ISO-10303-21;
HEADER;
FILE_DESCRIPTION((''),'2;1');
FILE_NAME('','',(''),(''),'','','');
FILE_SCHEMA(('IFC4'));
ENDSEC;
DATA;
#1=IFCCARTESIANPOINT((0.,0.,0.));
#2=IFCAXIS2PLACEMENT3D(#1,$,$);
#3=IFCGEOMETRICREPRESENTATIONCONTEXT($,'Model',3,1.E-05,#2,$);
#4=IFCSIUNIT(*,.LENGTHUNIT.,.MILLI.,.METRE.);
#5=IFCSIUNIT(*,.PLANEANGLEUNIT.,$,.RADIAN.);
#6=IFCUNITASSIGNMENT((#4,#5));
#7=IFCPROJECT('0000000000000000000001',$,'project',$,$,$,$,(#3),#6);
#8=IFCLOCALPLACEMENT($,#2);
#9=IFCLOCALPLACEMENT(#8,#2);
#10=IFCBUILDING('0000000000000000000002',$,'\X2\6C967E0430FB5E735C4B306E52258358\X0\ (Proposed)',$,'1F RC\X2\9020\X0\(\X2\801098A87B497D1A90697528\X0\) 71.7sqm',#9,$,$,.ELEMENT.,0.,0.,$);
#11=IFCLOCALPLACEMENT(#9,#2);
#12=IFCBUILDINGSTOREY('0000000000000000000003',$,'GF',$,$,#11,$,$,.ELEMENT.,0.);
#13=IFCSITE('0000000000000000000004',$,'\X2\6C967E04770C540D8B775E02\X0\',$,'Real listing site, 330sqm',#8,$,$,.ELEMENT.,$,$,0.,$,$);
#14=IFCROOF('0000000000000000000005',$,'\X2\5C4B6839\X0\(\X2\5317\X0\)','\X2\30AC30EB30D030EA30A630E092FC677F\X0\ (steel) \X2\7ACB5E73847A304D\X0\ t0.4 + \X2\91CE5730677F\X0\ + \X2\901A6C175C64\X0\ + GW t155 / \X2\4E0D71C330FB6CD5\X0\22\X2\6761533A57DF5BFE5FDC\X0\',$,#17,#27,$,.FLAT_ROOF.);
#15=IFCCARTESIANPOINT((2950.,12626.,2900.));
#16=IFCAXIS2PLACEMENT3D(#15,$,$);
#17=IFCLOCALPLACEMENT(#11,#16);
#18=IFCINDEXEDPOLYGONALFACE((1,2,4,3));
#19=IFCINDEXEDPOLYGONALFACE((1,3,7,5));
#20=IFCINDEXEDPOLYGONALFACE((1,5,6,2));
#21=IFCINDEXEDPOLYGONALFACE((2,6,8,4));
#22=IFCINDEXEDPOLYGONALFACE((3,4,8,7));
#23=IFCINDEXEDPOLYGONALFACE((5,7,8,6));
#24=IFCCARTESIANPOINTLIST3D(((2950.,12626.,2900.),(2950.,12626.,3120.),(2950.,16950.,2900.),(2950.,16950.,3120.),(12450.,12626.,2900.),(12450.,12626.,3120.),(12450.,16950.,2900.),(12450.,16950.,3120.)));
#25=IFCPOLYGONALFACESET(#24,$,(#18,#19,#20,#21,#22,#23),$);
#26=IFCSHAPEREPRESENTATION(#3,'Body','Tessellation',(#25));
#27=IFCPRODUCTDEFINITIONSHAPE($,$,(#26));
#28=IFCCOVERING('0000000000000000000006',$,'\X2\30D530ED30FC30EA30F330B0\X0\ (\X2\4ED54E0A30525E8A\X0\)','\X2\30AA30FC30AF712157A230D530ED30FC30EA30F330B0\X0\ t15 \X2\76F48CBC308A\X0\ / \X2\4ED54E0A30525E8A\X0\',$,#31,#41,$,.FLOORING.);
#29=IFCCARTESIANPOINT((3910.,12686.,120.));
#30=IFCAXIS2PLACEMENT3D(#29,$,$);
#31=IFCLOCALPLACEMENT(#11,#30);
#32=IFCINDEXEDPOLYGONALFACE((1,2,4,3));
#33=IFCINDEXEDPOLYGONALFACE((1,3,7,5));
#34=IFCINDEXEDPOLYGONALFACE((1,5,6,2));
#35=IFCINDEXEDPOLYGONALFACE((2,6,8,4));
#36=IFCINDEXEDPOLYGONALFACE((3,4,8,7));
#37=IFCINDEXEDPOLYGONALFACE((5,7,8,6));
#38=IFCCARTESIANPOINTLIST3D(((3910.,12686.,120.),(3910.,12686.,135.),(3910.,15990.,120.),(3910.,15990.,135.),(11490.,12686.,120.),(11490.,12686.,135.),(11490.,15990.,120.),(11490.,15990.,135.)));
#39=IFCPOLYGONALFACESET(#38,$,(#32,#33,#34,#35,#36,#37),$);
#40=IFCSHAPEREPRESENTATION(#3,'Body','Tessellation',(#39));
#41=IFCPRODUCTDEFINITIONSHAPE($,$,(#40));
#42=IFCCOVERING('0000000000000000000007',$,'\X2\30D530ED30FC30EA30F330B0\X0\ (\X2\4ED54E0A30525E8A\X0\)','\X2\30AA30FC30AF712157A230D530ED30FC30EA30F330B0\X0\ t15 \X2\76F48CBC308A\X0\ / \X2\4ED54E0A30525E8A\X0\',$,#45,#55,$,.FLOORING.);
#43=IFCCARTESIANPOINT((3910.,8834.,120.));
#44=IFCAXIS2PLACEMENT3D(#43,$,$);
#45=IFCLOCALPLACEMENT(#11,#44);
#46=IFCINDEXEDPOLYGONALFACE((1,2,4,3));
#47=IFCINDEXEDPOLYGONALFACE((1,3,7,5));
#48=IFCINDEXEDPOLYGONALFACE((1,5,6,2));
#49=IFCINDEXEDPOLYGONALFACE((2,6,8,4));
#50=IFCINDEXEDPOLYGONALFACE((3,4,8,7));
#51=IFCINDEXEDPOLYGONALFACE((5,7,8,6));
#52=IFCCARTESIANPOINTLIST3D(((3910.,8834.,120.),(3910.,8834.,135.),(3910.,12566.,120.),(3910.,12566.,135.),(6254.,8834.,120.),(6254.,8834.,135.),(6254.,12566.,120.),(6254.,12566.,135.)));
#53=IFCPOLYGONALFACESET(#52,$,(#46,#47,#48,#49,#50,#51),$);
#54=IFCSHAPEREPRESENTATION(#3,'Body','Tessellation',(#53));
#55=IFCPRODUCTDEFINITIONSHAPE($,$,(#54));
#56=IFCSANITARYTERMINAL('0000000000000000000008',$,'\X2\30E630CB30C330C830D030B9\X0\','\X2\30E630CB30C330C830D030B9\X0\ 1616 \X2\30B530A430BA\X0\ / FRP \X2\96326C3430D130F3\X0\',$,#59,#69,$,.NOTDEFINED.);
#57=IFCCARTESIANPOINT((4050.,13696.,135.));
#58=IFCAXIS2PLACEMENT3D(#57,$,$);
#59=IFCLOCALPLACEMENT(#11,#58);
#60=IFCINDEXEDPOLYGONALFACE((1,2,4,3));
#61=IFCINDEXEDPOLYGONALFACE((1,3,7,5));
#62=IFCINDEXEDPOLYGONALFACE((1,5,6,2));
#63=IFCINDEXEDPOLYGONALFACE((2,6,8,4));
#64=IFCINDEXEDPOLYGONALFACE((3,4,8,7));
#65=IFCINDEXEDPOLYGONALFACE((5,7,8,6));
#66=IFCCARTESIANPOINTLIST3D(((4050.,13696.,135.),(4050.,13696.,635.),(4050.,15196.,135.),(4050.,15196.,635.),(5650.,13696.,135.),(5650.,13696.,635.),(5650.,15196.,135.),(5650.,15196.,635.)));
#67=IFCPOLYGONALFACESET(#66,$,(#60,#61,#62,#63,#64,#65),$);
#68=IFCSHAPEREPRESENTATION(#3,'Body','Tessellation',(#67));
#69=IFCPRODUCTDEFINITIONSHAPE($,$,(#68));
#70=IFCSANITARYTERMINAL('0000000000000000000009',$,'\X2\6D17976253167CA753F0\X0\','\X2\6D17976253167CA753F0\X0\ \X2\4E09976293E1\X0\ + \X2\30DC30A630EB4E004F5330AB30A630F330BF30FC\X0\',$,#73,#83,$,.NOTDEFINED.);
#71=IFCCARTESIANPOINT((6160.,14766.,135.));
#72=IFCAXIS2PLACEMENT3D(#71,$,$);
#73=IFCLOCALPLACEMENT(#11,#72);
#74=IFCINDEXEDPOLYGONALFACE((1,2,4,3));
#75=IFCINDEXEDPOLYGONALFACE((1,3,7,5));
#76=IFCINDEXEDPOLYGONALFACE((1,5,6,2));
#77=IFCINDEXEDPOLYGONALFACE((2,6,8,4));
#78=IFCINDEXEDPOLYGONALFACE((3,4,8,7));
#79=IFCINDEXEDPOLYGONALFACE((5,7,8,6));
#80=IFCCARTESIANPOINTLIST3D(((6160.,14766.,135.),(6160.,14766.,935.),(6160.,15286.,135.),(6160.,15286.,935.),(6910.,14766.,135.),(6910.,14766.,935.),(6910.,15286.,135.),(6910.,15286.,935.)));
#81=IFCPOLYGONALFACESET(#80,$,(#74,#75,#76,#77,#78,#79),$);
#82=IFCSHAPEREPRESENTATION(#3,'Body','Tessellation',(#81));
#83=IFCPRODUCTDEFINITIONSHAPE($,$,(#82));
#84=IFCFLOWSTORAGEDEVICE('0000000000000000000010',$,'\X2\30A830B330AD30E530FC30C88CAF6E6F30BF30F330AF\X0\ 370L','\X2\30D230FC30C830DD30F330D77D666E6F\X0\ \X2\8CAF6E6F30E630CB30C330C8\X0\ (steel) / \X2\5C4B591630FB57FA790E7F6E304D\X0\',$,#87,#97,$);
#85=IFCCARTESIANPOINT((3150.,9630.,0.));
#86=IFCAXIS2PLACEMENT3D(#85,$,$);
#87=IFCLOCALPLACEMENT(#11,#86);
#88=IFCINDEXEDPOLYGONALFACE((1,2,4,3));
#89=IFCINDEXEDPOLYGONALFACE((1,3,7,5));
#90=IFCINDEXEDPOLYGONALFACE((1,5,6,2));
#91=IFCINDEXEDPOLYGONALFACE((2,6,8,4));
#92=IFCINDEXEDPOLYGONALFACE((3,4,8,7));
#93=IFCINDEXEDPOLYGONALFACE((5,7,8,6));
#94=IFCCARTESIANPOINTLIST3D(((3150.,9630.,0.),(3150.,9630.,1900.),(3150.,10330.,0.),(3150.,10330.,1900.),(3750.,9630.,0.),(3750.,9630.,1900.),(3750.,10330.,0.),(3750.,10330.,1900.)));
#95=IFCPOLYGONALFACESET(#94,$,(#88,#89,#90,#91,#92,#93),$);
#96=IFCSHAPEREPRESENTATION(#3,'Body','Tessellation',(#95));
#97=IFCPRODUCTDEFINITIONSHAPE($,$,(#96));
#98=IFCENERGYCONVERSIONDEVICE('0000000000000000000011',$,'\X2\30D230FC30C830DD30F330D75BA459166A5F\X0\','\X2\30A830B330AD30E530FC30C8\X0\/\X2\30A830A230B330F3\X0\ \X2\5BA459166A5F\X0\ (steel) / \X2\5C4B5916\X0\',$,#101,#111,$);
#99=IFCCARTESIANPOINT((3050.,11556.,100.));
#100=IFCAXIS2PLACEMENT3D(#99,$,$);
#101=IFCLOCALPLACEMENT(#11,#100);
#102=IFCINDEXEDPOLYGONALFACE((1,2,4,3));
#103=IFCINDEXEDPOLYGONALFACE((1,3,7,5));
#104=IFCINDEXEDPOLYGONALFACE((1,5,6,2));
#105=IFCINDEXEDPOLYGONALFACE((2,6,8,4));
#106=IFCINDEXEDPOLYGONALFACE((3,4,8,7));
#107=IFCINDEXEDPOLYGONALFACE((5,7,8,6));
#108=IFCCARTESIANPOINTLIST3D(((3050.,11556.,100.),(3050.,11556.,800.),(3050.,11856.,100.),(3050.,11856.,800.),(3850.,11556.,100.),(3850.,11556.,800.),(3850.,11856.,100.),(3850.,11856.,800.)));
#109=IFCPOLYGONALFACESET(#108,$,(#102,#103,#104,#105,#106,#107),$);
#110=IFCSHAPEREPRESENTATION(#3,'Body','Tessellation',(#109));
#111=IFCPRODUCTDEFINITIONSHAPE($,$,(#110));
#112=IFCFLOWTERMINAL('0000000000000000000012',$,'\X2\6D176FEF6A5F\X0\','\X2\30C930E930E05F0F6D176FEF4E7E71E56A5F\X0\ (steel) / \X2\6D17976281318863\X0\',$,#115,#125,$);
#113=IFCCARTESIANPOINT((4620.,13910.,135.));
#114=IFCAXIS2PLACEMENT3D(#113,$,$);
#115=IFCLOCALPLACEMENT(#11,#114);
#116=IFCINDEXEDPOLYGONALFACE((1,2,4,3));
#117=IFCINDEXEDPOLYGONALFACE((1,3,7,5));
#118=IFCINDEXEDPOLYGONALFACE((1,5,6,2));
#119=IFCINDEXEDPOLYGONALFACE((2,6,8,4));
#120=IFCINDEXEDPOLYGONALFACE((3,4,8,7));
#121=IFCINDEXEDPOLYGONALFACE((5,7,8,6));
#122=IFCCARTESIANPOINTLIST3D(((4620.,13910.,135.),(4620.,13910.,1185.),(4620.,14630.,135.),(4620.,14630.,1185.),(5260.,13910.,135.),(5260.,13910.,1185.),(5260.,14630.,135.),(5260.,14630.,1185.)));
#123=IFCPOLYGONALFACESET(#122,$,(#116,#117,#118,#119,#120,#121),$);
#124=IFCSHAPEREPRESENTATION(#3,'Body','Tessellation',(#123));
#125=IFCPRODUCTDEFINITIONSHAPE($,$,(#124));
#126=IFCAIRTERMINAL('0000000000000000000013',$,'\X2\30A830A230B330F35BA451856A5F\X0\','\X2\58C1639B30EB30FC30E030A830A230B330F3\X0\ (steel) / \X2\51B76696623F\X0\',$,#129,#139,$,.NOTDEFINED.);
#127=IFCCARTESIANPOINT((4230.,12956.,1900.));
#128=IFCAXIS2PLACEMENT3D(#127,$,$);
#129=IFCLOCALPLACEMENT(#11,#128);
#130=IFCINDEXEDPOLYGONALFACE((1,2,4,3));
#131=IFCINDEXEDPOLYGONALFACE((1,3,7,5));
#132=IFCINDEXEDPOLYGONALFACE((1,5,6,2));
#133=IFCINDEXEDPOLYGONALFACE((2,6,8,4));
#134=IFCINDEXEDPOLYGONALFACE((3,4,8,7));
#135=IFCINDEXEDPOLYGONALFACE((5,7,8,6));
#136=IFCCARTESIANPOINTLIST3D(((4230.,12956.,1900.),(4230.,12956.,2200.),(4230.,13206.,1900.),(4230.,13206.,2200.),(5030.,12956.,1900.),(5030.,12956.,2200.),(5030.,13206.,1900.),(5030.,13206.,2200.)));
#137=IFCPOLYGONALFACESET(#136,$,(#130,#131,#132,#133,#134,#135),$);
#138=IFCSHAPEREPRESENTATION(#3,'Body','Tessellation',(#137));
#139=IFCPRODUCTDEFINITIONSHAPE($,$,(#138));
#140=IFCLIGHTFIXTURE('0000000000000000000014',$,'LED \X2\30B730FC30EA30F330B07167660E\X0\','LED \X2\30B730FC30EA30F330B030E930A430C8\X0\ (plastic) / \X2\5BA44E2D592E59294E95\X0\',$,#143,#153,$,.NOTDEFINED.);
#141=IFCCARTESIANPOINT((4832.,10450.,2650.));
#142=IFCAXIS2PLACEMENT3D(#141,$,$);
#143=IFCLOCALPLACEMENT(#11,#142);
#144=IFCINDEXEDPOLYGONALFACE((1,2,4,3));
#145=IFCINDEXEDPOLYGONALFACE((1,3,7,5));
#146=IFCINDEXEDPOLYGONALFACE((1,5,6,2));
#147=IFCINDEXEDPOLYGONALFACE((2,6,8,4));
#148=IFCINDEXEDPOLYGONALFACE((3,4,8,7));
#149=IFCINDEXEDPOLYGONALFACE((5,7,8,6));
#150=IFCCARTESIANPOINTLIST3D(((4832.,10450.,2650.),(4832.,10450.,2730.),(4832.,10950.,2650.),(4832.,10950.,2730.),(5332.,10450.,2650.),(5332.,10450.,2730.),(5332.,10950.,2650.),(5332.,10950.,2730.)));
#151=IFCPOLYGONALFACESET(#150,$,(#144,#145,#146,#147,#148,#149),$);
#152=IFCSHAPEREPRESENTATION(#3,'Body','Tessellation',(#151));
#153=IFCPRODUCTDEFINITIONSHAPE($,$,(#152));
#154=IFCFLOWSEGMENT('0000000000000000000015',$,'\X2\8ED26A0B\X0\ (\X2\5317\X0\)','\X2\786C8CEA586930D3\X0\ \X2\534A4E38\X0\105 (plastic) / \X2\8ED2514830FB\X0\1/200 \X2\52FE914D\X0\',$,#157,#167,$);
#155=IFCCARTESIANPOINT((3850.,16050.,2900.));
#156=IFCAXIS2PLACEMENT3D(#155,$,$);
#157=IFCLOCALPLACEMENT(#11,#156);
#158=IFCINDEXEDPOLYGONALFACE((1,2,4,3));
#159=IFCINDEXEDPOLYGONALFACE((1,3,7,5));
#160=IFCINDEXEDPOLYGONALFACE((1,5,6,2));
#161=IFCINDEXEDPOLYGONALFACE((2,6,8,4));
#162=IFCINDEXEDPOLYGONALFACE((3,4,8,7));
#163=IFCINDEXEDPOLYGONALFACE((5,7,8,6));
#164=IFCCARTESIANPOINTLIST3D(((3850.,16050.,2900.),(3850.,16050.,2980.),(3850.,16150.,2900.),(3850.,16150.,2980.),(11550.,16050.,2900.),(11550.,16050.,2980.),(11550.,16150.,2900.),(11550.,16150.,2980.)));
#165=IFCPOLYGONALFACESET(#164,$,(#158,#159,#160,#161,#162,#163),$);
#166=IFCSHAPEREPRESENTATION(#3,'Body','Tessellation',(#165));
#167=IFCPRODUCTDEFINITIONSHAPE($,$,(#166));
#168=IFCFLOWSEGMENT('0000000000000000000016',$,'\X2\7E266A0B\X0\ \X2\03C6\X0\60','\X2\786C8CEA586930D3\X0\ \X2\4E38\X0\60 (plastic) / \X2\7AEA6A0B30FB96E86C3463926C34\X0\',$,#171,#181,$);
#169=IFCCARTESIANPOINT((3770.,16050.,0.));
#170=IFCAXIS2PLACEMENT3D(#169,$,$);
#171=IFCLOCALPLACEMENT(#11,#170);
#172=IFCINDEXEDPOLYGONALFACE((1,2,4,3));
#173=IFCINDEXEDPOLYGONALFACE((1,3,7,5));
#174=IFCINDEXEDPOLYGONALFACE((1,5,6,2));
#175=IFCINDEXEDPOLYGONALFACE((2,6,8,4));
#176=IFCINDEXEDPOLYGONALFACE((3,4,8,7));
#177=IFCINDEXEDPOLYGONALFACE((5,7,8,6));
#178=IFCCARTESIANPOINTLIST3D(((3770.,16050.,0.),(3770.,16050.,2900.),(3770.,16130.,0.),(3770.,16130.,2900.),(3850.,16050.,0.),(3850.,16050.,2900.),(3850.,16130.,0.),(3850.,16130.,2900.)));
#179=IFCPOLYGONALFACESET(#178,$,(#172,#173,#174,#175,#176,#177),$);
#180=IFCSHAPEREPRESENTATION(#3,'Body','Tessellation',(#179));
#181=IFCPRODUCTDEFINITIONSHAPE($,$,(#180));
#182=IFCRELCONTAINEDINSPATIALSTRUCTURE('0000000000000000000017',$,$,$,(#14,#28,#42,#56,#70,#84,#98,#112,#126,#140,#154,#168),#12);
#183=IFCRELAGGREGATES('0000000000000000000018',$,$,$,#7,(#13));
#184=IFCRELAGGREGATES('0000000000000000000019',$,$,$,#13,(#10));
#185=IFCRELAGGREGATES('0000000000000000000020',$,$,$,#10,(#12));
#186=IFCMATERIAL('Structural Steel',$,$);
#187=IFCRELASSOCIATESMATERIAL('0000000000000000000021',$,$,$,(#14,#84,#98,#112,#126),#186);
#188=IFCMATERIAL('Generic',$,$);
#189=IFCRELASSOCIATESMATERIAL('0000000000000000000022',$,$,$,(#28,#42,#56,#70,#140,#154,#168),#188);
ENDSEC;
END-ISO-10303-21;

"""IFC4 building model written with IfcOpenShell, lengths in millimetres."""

from ifc_helpers import new_model, si_unit, frame, frame_2d, origin, place, context, project, spatial, rectangle, extrude, material, element, save


model = new_model("IFC4")

# Units and contexts
model_context = context("Model", 3, precision=1e-05, world=origin())
ifc_project = project(units=[si_unit("LENGTHUNIT", "METRE", prefix="MILLI"), si_unit("PLANEANGLEUNIT", "RADIAN")], contexts=[model_context])

# Site, building, storey
site_placement = place(None, origin())
site = spatial("IfcSite", under=ifc_project, at=site_placement, Name="沖縄県名護市", ObjectType="Real listing site, 330sqm", CompositionType="ELEMENT", RefElevation=0.0)
building_placement = place(site_placement, origin())
building = spatial("IfcBuilding", under=site, at=building_placement, Name="沖縄・平屋の別荘 (Proposed)", ObjectType="1F RC造(耐風等級適用) 71.7sqm", CompositionType="ELEMENT", ElevationOfRefHeight=0.0, ElevationOfTerrain=0.0)
storey_placement = place(building_placement, origin())
storey = spatial("IfcBuildingStorey", under=building, at=storey_placement, Name="GF", CompositionType="ELEMENT", Elevation=0.0)

# Roof
ifc_material_1 = material(Name="Structural Steel")
roof_placement = place(storey_placement, frame((2950.0, 12626.0, 2900.0)))
element("IfcRoof", 1, at=roof_placement, inside=storey, material=ifc_material_1, Name="屋根(北)", Description="ガルバリウム鋼板 (steel) 立平葺き t0.4 + 野地板 + 通気層 + GW t155 / 不燃・法22条区域対応", PredefinedType="FLAT_ROOF", context=model_context, shape_type="SweptSolid", body=[
    extrude(rectangle(XDim=9500.0, YDim=4324.0, at=frame_2d((4750.0, 2162.0))), frame((2950.0, 12626.0, 2900.0)), (0.0, 0.0, 1.0), 220.0),
])

# Coverings
ifc_material_2 = material(Name="Generic")
covering_1_placement = place(storey_placement, frame((3910.0, 12686.0, 120.0)))
element("IfcCovering", 2, at=covering_1_placement, inside=storey, material=ifc_material_2, Name="フローリング (仕上げ床)", Description="オーク無垢フローリング t15 直貼り / 仕上げ床", PredefinedType="FLOORING", context=model_context, shape_type="SweptSolid", body=[
    extrude(rectangle(XDim=7580.0, YDim=3304.0, at=frame_2d((3790.0, 1652.0))), frame((3910.0, 12686.0, 120.0)), (0.0, 0.0, 1.0), 15.0),
])
covering_2_placement = place(storey_placement, frame((3910.0, 8834.0, 120.0)))
element("IfcCovering", 3, at=covering_2_placement, inside=storey, material=ifc_material_2, Name="フローリング (仕上げ床)", Description="オーク無垢フローリング t15 直貼り / 仕上げ床", PredefinedType="FLOORING", context=model_context, shape_type="SweptSolid", body=[
    extrude(rectangle(XDim=2344.0, YDim=3732.0, at=frame_2d((1172.0, 1866.0))), frame((3910.0, 8834.0, 120.0)), (0.0, 0.0, 1.0), 15.0),
])

# Sanitary terminals
sanitary_terminal_1_placement = place(storey_placement, frame((4050.0, 13696.0, 135.0)))
element("IfcSanitaryTerminal", 4, at=sanitary_terminal_1_placement, inside=storey, material=ifc_material_2, Name="ユニットバス", Description="ユニットバス 1616 サイズ / FRP 防水パン", PredefinedType="NOTDEFINED", context=model_context, shape_type="SweptSolid", body=[
    extrude(rectangle(XDim=1600.0, YDim=1500.0, at=frame_2d((800.0, 750.0))), frame((4050.0, 13696.0, 135.0)), (0.0, 0.0, 1.0), 500.0),
])
sanitary_terminal_2_placement = place(storey_placement, frame((6160.0, 14766.0, 135.0)))
element("IfcSanitaryTerminal", 5, at=sanitary_terminal_2_placement, inside=storey, material=ifc_material_2, Name="洗面化粧台", Description="洗面化粧台 三面鏡 + ボウル一体カウンター", PredefinedType="NOTDEFINED", context=model_context, shape_type="SweptSolid", body=[
    extrude(rectangle(XDim=750.0, YDim=520.0, at=frame_2d((375.0, 260.0))), frame((6160.0, 14766.0, 135.0)), (0.0, 0.0, 1.0), 800.0),
])

# Flow storage device
flow_storage_device_placement = place(storey_placement, frame((3150.0, 9630.0, 0.0)))
element("IfcFlowStorageDevice", 6, at=flow_storage_device_placement, inside=storey, material=ifc_material_1, Name="エコキュート貯湯タンク 370L", Description="ヒートポンプ給湯 貯湯ユニット (steel) / 屋外・基礎置き", context=model_context, shape_type="SweptSolid", body=[
    extrude(rectangle(XDim=600.0, YDim=700.0, at=frame_2d((300.0, 350.0))), frame((3150.0, 9630.0, 0.0)), (0.0, 0.0, 1.0), 1900.0),
])

# Energy conversion device
energy_conversion_device_placement = place(storey_placement, frame((3050.0, 11556.0, 100.0)))
element("IfcEnergyConversionDevice", 7, at=energy_conversion_device_placement, inside=storey, material=ifc_material_1, Name="ヒートポンプ室外機", Description="エコキュート/エアコン 室外機 (steel) / 屋外", context=model_context, shape_type="SweptSolid", body=[
    extrude(rectangle(XDim=800.0, YDim=300.0, at=frame_2d((400.0, 150.0))), frame((3050.0, 11556.0, 100.0)), (0.0, 0.0, 1.0), 700.0),
])

# Flow terminal
flow_terminal_placement = place(storey_placement, frame((4620.0, 13910.0, 135.0)))
element("IfcFlowTerminal", 8, at=flow_terminal_placement, inside=storey, material=ifc_material_1, Name="洗濯機", Description="ドラム式洗濯乾燥機 (steel) / 洗面脱衣", context=model_context, shape_type="SweptSolid", body=[
    extrude(rectangle(XDim=640.0, YDim=720.0, at=frame_2d((320.0, 360.0))), frame((4620.0, 13910.0, 135.0)), (0.0, 0.0, 1.0), 1050.0),
])

# Air terminal
air_terminal_placement = place(storey_placement, frame((4230.0, 12956.0, 1900.0)))
element("IfcAirTerminal", 9, at=air_terminal_placement, inside=storey, material=ifc_material_1, Name="エアコン室内機", Description="壁掛ルームエアコン (steel) / 冷暖房", PredefinedType="NOTDEFINED", context=model_context, shape_type="SweptSolid", body=[
    extrude(rectangle(XDim=800.0, YDim=250.0, at=frame_2d((400.0, 125.0))), frame((4230.0, 12956.0, 1900.0)), (0.0, 0.0, 1.0), 300.0),
])

# Light fixture
light_fixture_placement = place(storey_placement, frame((4832.0, 10450.0, 2650.0)))
element("IfcLightFixture", 10, at=light_fixture_placement, inside=storey, material=ifc_material_2, Name="LED シーリング照明", Description="LED シーリングライト (plastic) / 室中央天井", PredefinedType="NOTDEFINED", context=model_context, shape_type="SweptSolid", body=[
    extrude(rectangle(XDim=500.0, YDim=500.0, at=frame_2d((250.0, 250.0))), frame((4832.0, 10450.0, 2650.0)), (0.0, 0.0, 1.0), 80.0),
])

# Flow segments
flow_segment_1_placement = place(storey_placement, frame((3850.0, 16050.0, 2900.0)))
element("IfcFlowSegment", 11, at=flow_segment_1_placement, inside=storey, material=ifc_material_2, Name="軒樋 (北)", Description="硬質塩ビ 半丸105 (plastic) / 軒先・1/200 勾配", context=model_context, shape_type="SweptSolid", body=[
    extrude(rectangle(XDim=7700.0, YDim=100.0, at=frame_2d((3850.0, 50.0))), frame((3850.0, 16050.0, 2900.0)), (0.0, 0.0, 1.0), 80.0),
])
flow_segment_2_placement = place(storey_placement, frame((3770.0, 16050.0, 0.0)))
element("IfcFlowSegment", 12, at=flow_segment_2_placement, inside=storey, material=ifc_material_2, Name="縦樋 φ60", Description="硬質塩ビ 丸60 (plastic) / 竪樋・雨水排水", context=model_context, shape_type="SweptSolid", body=[
    extrude(rectangle(XDim=80.0, YDim=80.0, at=frame_2d((40.0, 40.0))), frame((3770.0, 16050.0, 0.0)), (0.0, 0.0, 1.0), 2900.0),
])

save(model, "model.ifc")
